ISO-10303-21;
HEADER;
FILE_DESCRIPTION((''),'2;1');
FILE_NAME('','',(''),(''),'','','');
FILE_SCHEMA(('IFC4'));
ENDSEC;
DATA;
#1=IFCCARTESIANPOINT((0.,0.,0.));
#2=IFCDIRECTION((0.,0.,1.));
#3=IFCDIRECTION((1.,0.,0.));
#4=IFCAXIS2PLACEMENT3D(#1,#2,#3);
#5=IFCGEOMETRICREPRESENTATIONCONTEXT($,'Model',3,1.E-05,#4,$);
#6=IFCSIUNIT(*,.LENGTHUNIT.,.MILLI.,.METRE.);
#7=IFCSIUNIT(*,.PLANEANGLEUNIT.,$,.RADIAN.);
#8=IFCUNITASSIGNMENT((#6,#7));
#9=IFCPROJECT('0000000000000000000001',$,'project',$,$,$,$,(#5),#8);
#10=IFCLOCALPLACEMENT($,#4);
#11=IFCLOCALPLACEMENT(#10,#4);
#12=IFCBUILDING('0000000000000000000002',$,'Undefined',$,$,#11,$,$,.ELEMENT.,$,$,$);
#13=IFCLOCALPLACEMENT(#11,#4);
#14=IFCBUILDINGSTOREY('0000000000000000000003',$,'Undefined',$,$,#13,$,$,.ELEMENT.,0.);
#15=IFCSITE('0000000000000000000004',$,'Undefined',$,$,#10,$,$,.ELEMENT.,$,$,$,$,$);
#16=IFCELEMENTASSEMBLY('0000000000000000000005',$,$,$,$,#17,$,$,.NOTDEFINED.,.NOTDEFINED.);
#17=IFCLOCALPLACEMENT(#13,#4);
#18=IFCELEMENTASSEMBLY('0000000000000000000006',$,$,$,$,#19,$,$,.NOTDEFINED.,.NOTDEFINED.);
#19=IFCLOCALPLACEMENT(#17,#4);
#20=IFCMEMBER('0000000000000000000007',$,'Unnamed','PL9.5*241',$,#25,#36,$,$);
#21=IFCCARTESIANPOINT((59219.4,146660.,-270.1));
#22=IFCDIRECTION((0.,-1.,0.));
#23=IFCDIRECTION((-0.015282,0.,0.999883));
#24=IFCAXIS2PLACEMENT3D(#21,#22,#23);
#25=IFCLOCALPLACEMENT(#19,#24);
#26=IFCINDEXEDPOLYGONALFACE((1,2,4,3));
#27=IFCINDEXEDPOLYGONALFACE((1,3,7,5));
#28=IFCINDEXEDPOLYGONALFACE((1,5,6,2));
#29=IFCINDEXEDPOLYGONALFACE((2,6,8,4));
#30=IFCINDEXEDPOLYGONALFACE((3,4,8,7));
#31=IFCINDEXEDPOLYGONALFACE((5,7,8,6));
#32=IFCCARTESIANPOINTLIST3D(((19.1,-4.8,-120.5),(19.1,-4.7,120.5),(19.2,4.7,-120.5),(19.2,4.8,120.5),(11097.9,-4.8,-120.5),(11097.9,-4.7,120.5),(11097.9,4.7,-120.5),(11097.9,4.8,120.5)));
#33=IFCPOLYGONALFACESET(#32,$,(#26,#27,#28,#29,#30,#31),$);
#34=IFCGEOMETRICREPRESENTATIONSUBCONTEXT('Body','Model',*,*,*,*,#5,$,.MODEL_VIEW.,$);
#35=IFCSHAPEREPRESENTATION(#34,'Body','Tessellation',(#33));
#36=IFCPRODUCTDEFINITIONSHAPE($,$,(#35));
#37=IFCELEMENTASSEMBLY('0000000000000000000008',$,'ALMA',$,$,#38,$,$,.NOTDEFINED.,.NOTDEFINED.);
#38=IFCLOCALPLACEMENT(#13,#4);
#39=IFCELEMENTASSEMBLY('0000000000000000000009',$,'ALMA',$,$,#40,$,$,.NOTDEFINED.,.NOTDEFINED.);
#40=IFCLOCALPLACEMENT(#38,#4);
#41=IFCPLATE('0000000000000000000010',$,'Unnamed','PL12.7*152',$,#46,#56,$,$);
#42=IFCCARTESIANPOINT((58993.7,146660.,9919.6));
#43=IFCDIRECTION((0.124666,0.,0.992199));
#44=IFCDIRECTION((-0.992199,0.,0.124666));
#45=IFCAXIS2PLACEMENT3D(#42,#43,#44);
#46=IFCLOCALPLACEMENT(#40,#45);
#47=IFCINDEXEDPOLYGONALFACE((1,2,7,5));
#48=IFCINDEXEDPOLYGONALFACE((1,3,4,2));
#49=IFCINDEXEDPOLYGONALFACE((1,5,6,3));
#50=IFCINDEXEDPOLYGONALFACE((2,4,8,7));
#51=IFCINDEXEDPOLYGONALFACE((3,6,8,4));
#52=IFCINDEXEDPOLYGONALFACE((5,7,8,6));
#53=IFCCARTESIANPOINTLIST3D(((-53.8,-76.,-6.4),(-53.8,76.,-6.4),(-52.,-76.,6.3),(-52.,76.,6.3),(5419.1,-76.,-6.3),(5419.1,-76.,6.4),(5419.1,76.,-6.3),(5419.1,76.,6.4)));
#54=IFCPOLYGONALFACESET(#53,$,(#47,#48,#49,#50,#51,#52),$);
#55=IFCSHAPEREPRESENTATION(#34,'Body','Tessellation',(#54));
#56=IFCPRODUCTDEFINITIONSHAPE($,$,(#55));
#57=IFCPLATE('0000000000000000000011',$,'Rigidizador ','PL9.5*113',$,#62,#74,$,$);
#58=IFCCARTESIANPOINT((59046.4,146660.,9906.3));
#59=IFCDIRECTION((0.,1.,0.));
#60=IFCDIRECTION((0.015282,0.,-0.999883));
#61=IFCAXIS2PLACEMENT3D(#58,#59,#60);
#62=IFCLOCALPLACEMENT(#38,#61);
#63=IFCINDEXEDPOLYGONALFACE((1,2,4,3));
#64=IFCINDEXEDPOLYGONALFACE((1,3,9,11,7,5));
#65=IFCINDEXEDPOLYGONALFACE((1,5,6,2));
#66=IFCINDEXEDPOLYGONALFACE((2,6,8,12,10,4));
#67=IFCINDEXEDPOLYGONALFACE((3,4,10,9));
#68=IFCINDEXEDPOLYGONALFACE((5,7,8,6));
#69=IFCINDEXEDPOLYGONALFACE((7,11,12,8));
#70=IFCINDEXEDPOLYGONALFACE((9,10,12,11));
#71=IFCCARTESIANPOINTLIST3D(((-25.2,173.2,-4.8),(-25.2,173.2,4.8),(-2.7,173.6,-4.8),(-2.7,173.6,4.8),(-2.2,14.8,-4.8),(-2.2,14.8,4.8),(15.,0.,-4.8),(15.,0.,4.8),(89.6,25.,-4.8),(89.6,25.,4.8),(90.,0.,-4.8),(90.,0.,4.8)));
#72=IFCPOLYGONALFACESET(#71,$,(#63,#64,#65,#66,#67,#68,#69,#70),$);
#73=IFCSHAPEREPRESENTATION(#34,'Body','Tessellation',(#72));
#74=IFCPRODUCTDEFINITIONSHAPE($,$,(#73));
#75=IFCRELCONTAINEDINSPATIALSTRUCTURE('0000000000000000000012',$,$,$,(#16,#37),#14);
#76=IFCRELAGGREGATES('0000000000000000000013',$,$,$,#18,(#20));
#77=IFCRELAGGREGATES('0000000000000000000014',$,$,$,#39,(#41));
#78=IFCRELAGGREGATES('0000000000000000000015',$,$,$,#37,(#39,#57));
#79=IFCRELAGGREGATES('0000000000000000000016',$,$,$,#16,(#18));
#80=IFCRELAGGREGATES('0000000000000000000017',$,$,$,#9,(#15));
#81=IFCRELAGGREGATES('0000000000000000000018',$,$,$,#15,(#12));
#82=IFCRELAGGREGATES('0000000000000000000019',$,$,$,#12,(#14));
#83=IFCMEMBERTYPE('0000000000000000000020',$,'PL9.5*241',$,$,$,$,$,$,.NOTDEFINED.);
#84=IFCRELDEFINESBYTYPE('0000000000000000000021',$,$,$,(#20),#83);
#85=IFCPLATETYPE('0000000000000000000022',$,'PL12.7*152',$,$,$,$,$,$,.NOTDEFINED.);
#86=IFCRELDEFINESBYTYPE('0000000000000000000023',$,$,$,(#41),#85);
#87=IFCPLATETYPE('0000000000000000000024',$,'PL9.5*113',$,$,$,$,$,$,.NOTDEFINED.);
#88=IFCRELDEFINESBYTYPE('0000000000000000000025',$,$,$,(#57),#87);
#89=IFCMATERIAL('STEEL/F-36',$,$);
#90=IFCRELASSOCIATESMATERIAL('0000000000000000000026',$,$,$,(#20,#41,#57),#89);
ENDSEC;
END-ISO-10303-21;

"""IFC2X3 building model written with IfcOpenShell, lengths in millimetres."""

from ifc_helpers import new_model, si_unit, frame, origin_with_axes, origin_2d_with_axis, place, context, subcontext, project, spatial, polyline, rectangle, outline, extrude, clip, halfspace, material, type_object, element, aggregate, save


model = new_model("IFC2X3")

# Units and contexts
model_context = context("Model", 3, precision=1e-05, world=origin_with_axes())
body_context = subcontext(model_context, "Body", "Model", "MODEL_VIEW")
ifc_project = project(units=[si_unit("LENGTHUNIT", "METRE", prefix="MILLI"), si_unit("PLANEANGLEUNIT", "RADIAN")], contexts=[model_context])

# Site, building, storey
site_placement = place(None, origin_with_axes())
site = spatial("IfcSite", under=ifc_project, at=site_placement, Name="Undefined", CompositionType="ELEMENT")
building_placement = place(site_placement, origin_with_axes())
building = spatial("IfcBuilding", under=site, at=building_placement, Name="Undefined", CompositionType="ELEMENT")
storey_placement = place(building_placement, origin_with_axes())
storey = spatial("IfcBuildingStorey", under=building, at=storey_placement, Name="Undefined", CompositionType="ELEMENT", Elevation=0.0)

# Element assemblies, member
assembly_1_placement = place(storey_placement, origin_with_axes())
assembly_1 = element("IfcElementAssembly", 1, at=assembly_1_placement, inside=storey, AssemblyPlace="NOTDEFINED", PredefinedType="NOTDEFINED")
assembly_2_placement = place(assembly_1_placement, origin_with_axes())
assembly_2 = element("IfcElementAssembly", 2, at=assembly_2_placement, AssemblyPlace="NOTDEFINED", PredefinedType="NOTDEFINED")
ifc_material_1 = material(Name="STEEL/F-36")
member_type = type_object("IfcMemberType", Name="PL9.5*241", PredefinedType="NOTDEFINED")
member_placement = place(assembly_2_placement, frame((59219.4, 146660.0, -270.1), z_axis=(0.0, -1.0, 0.0), x_axis=(-0.015282, 0.0, 0.999883)))
member = element("IfcMember", 3, at=member_placement, type_object=member_type, material=ifc_material_1, Name="Unnamed", Description="PL9.5*241", context=body_context, shape_type="Clipping", body=[
    clip(extrude(rectangle(XDim=9.5, YDim=241.0, at=origin_2d_with_axis()), frame((11097.9, 0.0, 0.0), z_axis=(-1.0, 0.0, 0.0), x_axis=(0.0, -1.0, 0.0)), (0.0, 0.0, 1.0), 11097.9), halfspace(frame((19.1, 0.0, 0.0), z_axis=(0.999883, -0.015282, 0.0), x_axis=(0.0, 0.0, 1.0)), True)),
])
aggregate(assembly_2, [member])

# Element assembly
assembly_3_placement = place(storey_placement, origin_with_axes())
assembly_3 = element("IfcElementAssembly", 4, at=assembly_3_placement, inside=storey, Name="ALMA", AssemblyPlace="NOTDEFINED", PredefinedType="NOTDEFINED")

# Element assembly, plate
assembly_4_placement = place(assembly_3_placement, origin_with_axes())
assembly_4 = element("IfcElementAssembly", 5, at=assembly_4_placement, Name="ALMA", AssemblyPlace="NOTDEFINED", PredefinedType="NOTDEFINED")
plate_type_1 = type_object("IfcPlateType", Name="PL12.7*152", PredefinedType="NOTDEFINED")
plate_1_placement = place(assembly_4_placement, frame((58993.7, 146660.0, 9919.6), z_axis=(0.124666, 0.0, 0.992199), x_axis=(-0.992199, 0.0, 0.124666)))
plate_1 = element("IfcPlate", 6, at=plate_1_placement, type_object=plate_type_1, material=ifc_material_1, Name="Unnamed", Description="PL12.7*152", context=body_context, shape_type="Clipping", body=[
    clip(extrude(outline(polyline([(-53.8, -76.0), (-53.8, 76.0), (5419.1, 76.0), (5419.1, -76.0), (-53.8, -76.0)])), frame((0.0, 0.0, -6.4), z_axis=(0.0, 0.0, 1.0), x_axis=(1.0, 0.0, 0.0)), (0.0, 0.0, 1.0), 12.7), halfspace(frame((-53.0, 0.0, -0.2), z_axis=(0.990178, 0.0, -0.139814), x_axis=(0.0, 1.0, 0.0)), True)),
])
aggregate(assembly_4, [plate_1])

# Plate
plate_type_2 = type_object("IfcPlateType", Name="PL9.5*113", PredefinedType="NOTDEFINED")
plate_2_placement = place(assembly_3_placement, frame((59046.4, 146660.0, 9906.3), z_axis=(0.0, 1.0, 0.0), x_axis=(0.015282, 0.0, -0.999883)))
plate_2 = element("IfcPlate", 7, at=plate_2_placement, type_object=plate_type_2, material=ifc_material_1, Name="Rigidizador ", Description="PL9.5*113", context=body_context, shape_type="SweptSolid", body=[
    extrude(outline(polyline([(-2.2, 14.8), (15.0, 0.0), (90.0, 0.0), (89.6, 25.0), (-2.7, 173.6), (-25.2, 173.2), (-2.2, 14.8)])), frame((0.0, 0.0, -4.8), z_axis=(0.0, 0.0, 1.0), x_axis=(1.0, 0.0, 0.0)), (0.0, 0.0, 1.0), 9.5),
])
aggregate(assembly_3, [assembly_4, plate_2])

aggregate(assembly_1, [assembly_2])

save(model, "model.ifc")
